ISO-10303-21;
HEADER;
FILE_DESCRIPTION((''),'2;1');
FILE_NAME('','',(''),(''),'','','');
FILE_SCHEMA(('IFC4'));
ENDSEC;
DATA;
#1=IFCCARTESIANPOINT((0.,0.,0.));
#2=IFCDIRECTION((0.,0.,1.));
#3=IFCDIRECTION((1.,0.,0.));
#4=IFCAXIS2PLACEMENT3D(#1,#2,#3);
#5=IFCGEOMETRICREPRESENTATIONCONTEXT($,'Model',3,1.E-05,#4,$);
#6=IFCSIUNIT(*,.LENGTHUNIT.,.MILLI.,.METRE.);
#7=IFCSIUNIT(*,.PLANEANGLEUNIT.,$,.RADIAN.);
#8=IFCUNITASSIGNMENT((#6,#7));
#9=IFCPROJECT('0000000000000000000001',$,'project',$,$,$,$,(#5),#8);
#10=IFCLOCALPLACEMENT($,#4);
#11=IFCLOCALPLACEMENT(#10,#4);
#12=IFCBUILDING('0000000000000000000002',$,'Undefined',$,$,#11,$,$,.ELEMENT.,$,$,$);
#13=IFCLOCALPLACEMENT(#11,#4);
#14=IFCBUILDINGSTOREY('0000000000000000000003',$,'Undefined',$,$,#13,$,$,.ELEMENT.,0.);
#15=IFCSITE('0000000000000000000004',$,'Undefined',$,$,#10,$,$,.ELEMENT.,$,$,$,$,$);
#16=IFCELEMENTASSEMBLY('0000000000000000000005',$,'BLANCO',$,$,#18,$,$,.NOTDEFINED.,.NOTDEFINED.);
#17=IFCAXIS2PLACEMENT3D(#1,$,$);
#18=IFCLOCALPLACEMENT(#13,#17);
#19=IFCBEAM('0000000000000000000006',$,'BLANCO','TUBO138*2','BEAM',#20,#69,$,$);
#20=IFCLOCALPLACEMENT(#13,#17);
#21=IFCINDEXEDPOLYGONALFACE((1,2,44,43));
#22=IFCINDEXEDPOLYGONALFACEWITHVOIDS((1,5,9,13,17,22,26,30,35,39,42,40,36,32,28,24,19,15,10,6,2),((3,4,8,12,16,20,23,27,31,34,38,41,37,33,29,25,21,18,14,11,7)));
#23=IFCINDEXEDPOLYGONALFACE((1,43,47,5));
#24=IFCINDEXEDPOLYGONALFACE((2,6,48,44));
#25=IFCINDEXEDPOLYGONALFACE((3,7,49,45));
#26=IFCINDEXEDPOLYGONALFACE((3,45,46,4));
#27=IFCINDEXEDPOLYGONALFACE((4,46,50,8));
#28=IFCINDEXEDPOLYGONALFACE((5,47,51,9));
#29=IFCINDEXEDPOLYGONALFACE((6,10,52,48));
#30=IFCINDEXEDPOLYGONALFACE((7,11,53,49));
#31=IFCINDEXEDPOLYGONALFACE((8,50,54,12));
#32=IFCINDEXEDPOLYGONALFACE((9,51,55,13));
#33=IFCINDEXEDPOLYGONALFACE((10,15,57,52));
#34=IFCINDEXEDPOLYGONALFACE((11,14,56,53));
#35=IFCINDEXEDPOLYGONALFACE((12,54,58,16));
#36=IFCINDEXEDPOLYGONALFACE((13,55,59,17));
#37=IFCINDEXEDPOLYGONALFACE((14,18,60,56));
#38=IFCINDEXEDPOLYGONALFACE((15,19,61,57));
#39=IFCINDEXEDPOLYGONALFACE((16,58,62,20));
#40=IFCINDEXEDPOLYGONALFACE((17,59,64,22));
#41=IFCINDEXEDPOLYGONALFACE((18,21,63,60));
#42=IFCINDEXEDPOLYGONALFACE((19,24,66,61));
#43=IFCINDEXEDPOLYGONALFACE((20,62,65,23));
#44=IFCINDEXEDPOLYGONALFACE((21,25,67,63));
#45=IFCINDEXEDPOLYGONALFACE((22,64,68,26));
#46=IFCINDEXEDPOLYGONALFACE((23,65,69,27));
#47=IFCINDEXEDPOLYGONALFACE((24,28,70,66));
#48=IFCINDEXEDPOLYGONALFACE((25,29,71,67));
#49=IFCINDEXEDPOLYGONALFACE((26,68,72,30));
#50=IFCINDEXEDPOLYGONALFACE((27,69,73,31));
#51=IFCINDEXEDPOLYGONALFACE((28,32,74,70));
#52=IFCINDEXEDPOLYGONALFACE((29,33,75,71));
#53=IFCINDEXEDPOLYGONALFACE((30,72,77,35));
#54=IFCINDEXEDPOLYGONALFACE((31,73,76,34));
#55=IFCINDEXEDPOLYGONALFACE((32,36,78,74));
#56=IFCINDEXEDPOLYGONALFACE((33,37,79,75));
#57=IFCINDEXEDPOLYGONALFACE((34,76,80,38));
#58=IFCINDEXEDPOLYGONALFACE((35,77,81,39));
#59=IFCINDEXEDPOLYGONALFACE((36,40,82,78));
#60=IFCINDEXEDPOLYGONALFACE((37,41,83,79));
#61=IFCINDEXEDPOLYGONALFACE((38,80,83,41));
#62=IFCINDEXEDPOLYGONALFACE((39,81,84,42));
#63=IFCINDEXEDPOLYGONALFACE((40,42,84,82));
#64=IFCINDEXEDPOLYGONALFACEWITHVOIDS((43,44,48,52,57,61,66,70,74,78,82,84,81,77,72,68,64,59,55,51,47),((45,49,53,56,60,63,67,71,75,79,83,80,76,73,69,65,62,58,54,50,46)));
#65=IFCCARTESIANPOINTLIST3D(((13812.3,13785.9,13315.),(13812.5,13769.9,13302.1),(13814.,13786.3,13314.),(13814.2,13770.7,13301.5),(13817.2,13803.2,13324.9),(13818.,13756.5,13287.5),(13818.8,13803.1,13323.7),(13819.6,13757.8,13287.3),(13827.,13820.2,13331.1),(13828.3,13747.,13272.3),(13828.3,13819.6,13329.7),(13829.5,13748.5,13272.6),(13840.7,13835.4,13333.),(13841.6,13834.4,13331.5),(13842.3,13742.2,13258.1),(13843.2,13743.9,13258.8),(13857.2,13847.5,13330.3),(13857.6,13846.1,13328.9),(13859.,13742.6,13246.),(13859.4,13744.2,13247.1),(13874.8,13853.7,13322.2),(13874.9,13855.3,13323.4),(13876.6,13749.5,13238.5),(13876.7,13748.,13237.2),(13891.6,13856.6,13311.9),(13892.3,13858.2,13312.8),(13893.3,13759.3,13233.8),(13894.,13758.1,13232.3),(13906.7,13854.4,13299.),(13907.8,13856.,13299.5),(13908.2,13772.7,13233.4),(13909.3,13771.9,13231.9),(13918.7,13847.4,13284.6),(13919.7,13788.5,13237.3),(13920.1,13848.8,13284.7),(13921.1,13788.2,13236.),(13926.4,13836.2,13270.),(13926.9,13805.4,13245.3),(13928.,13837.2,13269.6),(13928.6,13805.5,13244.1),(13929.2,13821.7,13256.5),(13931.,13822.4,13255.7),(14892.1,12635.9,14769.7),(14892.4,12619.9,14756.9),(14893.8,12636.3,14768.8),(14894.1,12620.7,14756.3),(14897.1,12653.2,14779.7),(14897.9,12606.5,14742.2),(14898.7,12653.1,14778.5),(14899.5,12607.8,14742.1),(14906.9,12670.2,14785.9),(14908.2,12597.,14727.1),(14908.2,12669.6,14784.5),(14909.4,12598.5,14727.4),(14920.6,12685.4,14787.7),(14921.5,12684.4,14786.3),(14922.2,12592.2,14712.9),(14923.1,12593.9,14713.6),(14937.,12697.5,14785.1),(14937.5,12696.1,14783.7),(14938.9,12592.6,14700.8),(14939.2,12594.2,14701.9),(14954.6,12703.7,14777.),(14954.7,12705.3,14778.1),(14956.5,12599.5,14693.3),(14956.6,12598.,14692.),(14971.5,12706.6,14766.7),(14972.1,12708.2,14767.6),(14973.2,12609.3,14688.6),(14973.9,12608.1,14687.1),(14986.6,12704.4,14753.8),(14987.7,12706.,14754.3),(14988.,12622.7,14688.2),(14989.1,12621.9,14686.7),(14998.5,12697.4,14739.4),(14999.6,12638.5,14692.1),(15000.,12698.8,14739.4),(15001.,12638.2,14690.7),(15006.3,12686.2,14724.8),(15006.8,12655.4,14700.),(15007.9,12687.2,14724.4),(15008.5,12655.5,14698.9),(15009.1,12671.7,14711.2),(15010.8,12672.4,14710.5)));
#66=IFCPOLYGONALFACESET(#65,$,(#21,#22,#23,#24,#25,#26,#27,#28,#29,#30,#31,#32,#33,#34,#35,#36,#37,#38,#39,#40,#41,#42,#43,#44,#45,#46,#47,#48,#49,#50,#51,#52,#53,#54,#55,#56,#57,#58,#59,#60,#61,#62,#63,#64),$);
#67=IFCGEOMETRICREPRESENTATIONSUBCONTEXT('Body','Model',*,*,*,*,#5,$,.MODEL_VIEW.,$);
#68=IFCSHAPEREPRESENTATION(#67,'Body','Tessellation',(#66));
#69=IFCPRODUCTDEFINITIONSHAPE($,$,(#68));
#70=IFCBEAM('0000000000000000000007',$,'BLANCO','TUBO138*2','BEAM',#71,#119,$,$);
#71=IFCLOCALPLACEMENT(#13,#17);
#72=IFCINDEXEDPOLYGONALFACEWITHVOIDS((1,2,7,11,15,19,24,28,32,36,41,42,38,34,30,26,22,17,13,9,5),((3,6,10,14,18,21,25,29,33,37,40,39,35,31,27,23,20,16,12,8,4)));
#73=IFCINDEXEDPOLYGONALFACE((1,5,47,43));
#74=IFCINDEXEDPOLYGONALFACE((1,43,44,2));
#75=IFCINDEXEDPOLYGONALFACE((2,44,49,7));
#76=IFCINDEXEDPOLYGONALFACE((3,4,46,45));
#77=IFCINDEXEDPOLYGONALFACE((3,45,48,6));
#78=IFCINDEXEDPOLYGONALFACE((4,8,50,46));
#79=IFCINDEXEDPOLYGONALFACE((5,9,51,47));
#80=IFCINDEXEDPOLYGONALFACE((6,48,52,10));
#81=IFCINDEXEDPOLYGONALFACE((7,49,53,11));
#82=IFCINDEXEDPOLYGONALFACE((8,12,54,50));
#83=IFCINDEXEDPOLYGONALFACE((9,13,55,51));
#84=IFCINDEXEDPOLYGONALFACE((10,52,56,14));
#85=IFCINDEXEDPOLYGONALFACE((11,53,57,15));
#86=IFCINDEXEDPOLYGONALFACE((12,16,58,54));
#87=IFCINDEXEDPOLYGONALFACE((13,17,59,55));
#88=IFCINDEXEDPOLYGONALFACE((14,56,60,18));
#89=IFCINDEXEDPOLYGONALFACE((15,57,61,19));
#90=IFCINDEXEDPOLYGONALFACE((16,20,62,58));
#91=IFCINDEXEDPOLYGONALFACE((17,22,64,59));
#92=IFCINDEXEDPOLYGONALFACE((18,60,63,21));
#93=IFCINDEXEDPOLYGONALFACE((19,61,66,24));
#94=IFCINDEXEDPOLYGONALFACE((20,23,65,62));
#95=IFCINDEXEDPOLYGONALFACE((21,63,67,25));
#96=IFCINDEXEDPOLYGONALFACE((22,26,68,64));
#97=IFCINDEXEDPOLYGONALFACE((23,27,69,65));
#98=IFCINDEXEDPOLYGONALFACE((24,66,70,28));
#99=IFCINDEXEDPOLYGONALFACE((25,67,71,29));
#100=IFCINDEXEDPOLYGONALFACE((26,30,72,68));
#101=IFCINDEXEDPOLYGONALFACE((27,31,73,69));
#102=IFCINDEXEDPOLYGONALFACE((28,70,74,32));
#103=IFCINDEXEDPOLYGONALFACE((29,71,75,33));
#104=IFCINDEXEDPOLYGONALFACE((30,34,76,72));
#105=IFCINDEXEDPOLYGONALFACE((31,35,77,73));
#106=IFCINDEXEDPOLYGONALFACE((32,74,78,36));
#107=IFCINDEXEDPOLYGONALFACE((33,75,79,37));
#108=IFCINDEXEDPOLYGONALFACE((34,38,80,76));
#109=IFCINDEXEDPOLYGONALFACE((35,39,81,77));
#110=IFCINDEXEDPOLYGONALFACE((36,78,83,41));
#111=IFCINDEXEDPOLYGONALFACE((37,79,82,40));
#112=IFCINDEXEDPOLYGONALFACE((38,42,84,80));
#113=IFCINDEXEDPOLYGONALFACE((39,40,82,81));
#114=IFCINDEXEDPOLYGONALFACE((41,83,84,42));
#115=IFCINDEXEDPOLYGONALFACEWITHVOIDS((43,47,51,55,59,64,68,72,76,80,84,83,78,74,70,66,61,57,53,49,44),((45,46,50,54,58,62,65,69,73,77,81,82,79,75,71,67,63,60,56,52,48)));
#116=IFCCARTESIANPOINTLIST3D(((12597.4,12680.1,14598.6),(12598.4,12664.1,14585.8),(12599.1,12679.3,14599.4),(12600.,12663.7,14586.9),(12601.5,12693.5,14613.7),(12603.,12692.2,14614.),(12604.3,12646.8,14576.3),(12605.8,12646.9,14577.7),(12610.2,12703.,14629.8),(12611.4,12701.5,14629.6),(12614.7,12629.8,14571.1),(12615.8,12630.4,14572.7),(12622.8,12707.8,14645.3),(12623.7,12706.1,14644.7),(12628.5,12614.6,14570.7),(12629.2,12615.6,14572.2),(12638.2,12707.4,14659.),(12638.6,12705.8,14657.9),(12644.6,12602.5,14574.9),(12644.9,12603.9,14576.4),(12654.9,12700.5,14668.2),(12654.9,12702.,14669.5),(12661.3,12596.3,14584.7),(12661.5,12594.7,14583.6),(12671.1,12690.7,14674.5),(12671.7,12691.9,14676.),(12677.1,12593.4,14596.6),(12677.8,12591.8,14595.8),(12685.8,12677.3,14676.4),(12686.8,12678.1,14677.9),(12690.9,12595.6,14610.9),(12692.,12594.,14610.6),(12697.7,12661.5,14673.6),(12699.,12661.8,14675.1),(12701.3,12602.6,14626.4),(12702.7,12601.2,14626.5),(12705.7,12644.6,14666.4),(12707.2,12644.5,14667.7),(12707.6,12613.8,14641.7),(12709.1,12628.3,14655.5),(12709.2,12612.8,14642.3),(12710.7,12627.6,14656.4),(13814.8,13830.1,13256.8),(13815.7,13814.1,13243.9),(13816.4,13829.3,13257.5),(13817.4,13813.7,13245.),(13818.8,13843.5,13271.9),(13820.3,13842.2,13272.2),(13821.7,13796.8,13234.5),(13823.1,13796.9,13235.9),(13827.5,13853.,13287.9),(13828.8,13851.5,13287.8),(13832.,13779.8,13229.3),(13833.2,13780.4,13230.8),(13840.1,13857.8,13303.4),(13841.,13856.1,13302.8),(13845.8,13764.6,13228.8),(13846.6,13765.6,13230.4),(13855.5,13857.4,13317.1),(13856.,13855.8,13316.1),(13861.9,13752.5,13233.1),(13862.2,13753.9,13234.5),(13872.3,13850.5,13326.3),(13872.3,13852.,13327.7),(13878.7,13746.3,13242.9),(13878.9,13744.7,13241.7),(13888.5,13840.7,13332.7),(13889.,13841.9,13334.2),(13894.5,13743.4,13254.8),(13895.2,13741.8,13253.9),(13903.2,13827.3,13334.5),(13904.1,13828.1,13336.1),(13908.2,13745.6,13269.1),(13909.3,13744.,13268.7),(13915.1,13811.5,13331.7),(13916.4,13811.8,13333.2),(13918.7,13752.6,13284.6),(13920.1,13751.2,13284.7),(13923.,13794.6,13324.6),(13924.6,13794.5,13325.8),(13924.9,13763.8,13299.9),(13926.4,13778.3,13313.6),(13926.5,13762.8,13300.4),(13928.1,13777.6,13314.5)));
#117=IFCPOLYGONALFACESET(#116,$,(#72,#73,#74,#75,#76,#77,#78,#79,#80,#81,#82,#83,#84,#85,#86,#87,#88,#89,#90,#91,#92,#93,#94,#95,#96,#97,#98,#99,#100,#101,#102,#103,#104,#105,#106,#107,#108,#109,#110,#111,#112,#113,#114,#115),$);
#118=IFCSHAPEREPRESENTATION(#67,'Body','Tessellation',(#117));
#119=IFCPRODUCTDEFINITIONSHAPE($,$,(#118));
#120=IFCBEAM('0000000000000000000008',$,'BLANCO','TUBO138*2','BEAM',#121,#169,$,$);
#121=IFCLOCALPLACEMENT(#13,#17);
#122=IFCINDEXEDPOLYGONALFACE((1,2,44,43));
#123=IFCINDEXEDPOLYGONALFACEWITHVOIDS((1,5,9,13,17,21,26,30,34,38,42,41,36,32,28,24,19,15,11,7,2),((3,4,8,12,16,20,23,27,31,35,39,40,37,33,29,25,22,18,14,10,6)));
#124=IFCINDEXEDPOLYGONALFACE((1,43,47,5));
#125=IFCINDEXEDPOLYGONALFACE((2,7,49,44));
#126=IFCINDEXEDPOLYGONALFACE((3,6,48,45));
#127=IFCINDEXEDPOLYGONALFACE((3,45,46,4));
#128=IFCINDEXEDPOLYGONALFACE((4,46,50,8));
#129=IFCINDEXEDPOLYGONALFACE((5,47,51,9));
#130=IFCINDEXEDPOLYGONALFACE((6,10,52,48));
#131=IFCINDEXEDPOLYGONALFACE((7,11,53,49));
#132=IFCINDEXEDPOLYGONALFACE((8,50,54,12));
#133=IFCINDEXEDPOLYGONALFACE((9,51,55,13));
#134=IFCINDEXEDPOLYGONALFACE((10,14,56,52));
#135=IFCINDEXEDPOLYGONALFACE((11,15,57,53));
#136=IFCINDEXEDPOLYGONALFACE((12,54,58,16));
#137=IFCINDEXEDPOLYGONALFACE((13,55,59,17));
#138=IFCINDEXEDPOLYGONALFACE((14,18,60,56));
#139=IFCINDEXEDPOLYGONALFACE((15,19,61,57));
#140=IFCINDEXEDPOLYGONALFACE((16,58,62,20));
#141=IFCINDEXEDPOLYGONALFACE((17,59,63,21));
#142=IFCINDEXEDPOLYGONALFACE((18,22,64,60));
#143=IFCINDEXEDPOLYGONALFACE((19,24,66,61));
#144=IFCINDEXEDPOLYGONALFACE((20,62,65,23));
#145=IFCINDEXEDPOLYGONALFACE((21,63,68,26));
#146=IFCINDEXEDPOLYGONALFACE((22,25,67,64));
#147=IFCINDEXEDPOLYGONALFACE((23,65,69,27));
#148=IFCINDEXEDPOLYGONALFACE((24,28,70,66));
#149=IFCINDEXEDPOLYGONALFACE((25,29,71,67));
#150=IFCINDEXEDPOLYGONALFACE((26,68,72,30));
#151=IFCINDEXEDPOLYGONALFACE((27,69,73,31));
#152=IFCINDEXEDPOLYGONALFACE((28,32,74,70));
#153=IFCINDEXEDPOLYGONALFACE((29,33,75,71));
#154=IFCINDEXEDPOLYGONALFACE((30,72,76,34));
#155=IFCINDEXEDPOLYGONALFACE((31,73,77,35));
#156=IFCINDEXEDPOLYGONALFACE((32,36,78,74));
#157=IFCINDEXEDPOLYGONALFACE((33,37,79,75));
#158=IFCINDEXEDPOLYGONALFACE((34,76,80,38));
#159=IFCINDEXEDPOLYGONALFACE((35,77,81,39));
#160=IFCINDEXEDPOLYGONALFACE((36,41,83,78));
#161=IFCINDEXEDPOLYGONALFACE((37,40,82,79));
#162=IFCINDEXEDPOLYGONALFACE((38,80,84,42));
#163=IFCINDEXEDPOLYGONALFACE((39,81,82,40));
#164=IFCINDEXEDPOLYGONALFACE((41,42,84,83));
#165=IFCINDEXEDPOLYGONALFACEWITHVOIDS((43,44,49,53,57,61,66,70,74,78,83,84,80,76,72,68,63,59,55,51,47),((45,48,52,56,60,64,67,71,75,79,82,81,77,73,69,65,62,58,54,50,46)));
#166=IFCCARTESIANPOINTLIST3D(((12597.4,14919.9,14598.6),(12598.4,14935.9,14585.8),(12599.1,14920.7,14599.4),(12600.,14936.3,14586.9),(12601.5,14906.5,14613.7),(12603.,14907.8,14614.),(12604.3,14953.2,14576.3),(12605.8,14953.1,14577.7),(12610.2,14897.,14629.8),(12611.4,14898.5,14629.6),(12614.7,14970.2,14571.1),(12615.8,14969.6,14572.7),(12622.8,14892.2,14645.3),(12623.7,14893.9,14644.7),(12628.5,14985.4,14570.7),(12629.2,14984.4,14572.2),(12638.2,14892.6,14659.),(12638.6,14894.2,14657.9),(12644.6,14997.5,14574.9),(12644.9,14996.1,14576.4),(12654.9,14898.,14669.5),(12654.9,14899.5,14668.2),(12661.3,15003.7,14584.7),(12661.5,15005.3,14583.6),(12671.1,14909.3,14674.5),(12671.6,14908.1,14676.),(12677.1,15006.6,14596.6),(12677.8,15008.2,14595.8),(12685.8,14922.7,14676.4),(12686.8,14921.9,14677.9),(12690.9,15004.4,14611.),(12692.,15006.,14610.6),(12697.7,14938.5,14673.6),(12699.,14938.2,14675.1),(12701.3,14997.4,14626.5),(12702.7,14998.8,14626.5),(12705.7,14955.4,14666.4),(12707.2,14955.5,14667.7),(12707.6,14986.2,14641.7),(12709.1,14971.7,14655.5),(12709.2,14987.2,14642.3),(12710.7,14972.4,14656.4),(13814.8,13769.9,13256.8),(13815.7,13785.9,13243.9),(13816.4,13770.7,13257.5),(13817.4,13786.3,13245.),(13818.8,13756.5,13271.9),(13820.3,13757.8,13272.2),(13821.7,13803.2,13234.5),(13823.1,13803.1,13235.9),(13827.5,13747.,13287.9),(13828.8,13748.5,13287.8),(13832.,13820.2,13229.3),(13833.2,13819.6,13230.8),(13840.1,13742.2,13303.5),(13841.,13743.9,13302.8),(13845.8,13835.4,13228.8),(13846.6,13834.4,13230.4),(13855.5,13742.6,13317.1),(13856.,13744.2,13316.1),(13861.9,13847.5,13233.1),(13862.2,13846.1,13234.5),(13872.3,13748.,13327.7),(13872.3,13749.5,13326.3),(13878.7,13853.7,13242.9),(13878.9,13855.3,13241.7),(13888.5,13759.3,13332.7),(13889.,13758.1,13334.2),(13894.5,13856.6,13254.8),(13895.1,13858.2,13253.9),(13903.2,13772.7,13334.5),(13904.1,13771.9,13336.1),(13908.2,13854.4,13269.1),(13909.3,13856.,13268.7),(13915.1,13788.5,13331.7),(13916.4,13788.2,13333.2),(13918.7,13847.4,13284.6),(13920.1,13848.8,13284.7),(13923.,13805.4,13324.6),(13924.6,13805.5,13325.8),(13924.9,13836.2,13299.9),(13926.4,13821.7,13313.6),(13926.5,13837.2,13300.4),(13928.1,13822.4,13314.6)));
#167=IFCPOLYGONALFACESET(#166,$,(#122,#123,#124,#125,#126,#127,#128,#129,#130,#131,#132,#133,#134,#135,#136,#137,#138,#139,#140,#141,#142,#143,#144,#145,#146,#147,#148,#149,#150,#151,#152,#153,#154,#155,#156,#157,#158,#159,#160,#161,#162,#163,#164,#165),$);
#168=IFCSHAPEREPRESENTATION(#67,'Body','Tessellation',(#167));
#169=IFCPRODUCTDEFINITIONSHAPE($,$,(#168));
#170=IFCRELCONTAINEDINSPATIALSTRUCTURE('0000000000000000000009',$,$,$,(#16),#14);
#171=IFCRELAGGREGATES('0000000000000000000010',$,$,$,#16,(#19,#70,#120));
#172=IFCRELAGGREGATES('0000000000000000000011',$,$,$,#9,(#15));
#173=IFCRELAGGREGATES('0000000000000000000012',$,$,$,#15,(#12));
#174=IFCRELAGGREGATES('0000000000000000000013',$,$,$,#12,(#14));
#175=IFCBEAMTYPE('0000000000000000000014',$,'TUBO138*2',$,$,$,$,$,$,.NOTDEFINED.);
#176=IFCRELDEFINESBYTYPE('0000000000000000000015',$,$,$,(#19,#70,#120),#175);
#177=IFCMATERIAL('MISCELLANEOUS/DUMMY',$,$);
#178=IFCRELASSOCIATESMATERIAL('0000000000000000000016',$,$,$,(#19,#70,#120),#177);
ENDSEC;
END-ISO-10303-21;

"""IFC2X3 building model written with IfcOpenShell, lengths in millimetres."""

from ifc_helpers import new_model, si_unit, frame, origin_with_axes, origin_2d_with_axis, place, context, subcontext, project, spatial, hollow_circle, extrude, material, type_object, element, aggregate, save


model = new_model("IFC2X3")

# Units and contexts
model_context = context("Model", 3, precision=1e-05, world=origin_with_axes())
body_context = subcontext(model_context, "Body", "Model", "MODEL_VIEW")
ifc_project = project(units=[si_unit("LENGTHUNIT", "METRE", prefix="MILLI"), si_unit("PLANEANGLEUNIT", "RADIAN")], contexts=[model_context])

# Site, building, storey
site_placement = place(None, origin_with_axes())
site = spatial("IfcSite", under=ifc_project, at=site_placement, Name="Undefined", CompositionType="ELEMENT")
building_placement = place(site_placement, origin_with_axes())
building = spatial("IfcBuilding", under=site, at=building_placement, Name="Undefined", CompositionType="ELEMENT")
storey_placement = place(building_placement, origin_with_axes())
storey = spatial("IfcBuildingStorey", under=building, at=storey_placement, Name="Undefined", CompositionType="ELEMENT", Elevation=0.0)

# Element assembly, beams
assembly_placement = place(storey_placement, origin_with_axes())
assembly = element("IfcElementAssembly", 1, at=assembly_placement, inside=storey, Name="BLANCO", AssemblyPlace="NOTDEFINED", PredefinedType="NOTDEFINED")
ifc_material = material(Name="MISCELLANEOUS/DUMMY")
beam_type = type_object("IfcBeamType", Name="TUBO138*2", PredefinedType="NOTDEFINED")
beam_1_placement = place(assembly_placement, frame((13871.3, 13800.0, 13282.3), z_axis=(0.497966, -0.461316, -0.734314), x_axis=(0.503224, -0.535899, 0.677922)))
beam_1 = element("IfcBeam", 2, at=beam_1_placement, type_object=beam_type, material=ifc_material, Name="BLANCO", Description="TUBO138*2", ObjectType="BEAM", context=body_context, shape_type="SweptSolid", body=[
    extrude(hollow_circle(Radius=69.0, WallThickness=2.0, at=origin_2d_with_axis()), frame((2145.9, 0.0, 0.0), z_axis=(-1.0, 0.0, 0.0), x_axis=(0.0, -1.0, 0.0)), (0.0, 0.0, 1.0), 2145.9),
])
beam_2_placement = place(assembly_placement, frame((13871.3, 13800.0, 13282.3), z_axis=(-0.423552, -0.461316, -0.77961), x_axis=(-0.567282, -0.535899, 0.625303)))
beam_2 = element("IfcBeam", 3, at=beam_2_placement, type_object=beam_type, material=ifc_material, Name="BLANCO", Description="TUBO138*2", ObjectType="BEAM", context=body_context, shape_type="SweptSolid", body=[
    extrude(hollow_circle(Radius=69.0, WallThickness=2.0, at=origin_2d_with_axis()), frame((2145.9, 0.0, 0.0), z_axis=(-1.0, 0.0, 0.0), x_axis=(0.0, -1.0, 0.0)), (0.0, 0.0, 1.0), 2145.9),
])
beam_3_placement = place(assembly_placement, frame((12654.0, 14950.0, 14624.1), z_axis=(-0.423552, 0.461316, -0.77961), x_axis=(0.567282, -0.535899, -0.625303)))
beam_3 = element("IfcBeam", 4, at=beam_3_placement, type_object=beam_type, material=ifc_material, Name="BLANCO", Description="TUBO138*2", ObjectType="BEAM", context=body_context, shape_type="SweptSolid", body=[
    extrude(hollow_circle(Radius=69.0, WallThickness=2.0, at=origin_2d_with_axis()), frame((2145.9, 0.0, 0.0), z_axis=(-1.0, 0.0, 0.0), x_axis=(0.0, -1.0, 0.0)), (0.0, 0.0, 1.0), 2145.9),
])
aggregate(assembly, [beam_1, beam_2, beam_3])

save(model, "model.ifc")
